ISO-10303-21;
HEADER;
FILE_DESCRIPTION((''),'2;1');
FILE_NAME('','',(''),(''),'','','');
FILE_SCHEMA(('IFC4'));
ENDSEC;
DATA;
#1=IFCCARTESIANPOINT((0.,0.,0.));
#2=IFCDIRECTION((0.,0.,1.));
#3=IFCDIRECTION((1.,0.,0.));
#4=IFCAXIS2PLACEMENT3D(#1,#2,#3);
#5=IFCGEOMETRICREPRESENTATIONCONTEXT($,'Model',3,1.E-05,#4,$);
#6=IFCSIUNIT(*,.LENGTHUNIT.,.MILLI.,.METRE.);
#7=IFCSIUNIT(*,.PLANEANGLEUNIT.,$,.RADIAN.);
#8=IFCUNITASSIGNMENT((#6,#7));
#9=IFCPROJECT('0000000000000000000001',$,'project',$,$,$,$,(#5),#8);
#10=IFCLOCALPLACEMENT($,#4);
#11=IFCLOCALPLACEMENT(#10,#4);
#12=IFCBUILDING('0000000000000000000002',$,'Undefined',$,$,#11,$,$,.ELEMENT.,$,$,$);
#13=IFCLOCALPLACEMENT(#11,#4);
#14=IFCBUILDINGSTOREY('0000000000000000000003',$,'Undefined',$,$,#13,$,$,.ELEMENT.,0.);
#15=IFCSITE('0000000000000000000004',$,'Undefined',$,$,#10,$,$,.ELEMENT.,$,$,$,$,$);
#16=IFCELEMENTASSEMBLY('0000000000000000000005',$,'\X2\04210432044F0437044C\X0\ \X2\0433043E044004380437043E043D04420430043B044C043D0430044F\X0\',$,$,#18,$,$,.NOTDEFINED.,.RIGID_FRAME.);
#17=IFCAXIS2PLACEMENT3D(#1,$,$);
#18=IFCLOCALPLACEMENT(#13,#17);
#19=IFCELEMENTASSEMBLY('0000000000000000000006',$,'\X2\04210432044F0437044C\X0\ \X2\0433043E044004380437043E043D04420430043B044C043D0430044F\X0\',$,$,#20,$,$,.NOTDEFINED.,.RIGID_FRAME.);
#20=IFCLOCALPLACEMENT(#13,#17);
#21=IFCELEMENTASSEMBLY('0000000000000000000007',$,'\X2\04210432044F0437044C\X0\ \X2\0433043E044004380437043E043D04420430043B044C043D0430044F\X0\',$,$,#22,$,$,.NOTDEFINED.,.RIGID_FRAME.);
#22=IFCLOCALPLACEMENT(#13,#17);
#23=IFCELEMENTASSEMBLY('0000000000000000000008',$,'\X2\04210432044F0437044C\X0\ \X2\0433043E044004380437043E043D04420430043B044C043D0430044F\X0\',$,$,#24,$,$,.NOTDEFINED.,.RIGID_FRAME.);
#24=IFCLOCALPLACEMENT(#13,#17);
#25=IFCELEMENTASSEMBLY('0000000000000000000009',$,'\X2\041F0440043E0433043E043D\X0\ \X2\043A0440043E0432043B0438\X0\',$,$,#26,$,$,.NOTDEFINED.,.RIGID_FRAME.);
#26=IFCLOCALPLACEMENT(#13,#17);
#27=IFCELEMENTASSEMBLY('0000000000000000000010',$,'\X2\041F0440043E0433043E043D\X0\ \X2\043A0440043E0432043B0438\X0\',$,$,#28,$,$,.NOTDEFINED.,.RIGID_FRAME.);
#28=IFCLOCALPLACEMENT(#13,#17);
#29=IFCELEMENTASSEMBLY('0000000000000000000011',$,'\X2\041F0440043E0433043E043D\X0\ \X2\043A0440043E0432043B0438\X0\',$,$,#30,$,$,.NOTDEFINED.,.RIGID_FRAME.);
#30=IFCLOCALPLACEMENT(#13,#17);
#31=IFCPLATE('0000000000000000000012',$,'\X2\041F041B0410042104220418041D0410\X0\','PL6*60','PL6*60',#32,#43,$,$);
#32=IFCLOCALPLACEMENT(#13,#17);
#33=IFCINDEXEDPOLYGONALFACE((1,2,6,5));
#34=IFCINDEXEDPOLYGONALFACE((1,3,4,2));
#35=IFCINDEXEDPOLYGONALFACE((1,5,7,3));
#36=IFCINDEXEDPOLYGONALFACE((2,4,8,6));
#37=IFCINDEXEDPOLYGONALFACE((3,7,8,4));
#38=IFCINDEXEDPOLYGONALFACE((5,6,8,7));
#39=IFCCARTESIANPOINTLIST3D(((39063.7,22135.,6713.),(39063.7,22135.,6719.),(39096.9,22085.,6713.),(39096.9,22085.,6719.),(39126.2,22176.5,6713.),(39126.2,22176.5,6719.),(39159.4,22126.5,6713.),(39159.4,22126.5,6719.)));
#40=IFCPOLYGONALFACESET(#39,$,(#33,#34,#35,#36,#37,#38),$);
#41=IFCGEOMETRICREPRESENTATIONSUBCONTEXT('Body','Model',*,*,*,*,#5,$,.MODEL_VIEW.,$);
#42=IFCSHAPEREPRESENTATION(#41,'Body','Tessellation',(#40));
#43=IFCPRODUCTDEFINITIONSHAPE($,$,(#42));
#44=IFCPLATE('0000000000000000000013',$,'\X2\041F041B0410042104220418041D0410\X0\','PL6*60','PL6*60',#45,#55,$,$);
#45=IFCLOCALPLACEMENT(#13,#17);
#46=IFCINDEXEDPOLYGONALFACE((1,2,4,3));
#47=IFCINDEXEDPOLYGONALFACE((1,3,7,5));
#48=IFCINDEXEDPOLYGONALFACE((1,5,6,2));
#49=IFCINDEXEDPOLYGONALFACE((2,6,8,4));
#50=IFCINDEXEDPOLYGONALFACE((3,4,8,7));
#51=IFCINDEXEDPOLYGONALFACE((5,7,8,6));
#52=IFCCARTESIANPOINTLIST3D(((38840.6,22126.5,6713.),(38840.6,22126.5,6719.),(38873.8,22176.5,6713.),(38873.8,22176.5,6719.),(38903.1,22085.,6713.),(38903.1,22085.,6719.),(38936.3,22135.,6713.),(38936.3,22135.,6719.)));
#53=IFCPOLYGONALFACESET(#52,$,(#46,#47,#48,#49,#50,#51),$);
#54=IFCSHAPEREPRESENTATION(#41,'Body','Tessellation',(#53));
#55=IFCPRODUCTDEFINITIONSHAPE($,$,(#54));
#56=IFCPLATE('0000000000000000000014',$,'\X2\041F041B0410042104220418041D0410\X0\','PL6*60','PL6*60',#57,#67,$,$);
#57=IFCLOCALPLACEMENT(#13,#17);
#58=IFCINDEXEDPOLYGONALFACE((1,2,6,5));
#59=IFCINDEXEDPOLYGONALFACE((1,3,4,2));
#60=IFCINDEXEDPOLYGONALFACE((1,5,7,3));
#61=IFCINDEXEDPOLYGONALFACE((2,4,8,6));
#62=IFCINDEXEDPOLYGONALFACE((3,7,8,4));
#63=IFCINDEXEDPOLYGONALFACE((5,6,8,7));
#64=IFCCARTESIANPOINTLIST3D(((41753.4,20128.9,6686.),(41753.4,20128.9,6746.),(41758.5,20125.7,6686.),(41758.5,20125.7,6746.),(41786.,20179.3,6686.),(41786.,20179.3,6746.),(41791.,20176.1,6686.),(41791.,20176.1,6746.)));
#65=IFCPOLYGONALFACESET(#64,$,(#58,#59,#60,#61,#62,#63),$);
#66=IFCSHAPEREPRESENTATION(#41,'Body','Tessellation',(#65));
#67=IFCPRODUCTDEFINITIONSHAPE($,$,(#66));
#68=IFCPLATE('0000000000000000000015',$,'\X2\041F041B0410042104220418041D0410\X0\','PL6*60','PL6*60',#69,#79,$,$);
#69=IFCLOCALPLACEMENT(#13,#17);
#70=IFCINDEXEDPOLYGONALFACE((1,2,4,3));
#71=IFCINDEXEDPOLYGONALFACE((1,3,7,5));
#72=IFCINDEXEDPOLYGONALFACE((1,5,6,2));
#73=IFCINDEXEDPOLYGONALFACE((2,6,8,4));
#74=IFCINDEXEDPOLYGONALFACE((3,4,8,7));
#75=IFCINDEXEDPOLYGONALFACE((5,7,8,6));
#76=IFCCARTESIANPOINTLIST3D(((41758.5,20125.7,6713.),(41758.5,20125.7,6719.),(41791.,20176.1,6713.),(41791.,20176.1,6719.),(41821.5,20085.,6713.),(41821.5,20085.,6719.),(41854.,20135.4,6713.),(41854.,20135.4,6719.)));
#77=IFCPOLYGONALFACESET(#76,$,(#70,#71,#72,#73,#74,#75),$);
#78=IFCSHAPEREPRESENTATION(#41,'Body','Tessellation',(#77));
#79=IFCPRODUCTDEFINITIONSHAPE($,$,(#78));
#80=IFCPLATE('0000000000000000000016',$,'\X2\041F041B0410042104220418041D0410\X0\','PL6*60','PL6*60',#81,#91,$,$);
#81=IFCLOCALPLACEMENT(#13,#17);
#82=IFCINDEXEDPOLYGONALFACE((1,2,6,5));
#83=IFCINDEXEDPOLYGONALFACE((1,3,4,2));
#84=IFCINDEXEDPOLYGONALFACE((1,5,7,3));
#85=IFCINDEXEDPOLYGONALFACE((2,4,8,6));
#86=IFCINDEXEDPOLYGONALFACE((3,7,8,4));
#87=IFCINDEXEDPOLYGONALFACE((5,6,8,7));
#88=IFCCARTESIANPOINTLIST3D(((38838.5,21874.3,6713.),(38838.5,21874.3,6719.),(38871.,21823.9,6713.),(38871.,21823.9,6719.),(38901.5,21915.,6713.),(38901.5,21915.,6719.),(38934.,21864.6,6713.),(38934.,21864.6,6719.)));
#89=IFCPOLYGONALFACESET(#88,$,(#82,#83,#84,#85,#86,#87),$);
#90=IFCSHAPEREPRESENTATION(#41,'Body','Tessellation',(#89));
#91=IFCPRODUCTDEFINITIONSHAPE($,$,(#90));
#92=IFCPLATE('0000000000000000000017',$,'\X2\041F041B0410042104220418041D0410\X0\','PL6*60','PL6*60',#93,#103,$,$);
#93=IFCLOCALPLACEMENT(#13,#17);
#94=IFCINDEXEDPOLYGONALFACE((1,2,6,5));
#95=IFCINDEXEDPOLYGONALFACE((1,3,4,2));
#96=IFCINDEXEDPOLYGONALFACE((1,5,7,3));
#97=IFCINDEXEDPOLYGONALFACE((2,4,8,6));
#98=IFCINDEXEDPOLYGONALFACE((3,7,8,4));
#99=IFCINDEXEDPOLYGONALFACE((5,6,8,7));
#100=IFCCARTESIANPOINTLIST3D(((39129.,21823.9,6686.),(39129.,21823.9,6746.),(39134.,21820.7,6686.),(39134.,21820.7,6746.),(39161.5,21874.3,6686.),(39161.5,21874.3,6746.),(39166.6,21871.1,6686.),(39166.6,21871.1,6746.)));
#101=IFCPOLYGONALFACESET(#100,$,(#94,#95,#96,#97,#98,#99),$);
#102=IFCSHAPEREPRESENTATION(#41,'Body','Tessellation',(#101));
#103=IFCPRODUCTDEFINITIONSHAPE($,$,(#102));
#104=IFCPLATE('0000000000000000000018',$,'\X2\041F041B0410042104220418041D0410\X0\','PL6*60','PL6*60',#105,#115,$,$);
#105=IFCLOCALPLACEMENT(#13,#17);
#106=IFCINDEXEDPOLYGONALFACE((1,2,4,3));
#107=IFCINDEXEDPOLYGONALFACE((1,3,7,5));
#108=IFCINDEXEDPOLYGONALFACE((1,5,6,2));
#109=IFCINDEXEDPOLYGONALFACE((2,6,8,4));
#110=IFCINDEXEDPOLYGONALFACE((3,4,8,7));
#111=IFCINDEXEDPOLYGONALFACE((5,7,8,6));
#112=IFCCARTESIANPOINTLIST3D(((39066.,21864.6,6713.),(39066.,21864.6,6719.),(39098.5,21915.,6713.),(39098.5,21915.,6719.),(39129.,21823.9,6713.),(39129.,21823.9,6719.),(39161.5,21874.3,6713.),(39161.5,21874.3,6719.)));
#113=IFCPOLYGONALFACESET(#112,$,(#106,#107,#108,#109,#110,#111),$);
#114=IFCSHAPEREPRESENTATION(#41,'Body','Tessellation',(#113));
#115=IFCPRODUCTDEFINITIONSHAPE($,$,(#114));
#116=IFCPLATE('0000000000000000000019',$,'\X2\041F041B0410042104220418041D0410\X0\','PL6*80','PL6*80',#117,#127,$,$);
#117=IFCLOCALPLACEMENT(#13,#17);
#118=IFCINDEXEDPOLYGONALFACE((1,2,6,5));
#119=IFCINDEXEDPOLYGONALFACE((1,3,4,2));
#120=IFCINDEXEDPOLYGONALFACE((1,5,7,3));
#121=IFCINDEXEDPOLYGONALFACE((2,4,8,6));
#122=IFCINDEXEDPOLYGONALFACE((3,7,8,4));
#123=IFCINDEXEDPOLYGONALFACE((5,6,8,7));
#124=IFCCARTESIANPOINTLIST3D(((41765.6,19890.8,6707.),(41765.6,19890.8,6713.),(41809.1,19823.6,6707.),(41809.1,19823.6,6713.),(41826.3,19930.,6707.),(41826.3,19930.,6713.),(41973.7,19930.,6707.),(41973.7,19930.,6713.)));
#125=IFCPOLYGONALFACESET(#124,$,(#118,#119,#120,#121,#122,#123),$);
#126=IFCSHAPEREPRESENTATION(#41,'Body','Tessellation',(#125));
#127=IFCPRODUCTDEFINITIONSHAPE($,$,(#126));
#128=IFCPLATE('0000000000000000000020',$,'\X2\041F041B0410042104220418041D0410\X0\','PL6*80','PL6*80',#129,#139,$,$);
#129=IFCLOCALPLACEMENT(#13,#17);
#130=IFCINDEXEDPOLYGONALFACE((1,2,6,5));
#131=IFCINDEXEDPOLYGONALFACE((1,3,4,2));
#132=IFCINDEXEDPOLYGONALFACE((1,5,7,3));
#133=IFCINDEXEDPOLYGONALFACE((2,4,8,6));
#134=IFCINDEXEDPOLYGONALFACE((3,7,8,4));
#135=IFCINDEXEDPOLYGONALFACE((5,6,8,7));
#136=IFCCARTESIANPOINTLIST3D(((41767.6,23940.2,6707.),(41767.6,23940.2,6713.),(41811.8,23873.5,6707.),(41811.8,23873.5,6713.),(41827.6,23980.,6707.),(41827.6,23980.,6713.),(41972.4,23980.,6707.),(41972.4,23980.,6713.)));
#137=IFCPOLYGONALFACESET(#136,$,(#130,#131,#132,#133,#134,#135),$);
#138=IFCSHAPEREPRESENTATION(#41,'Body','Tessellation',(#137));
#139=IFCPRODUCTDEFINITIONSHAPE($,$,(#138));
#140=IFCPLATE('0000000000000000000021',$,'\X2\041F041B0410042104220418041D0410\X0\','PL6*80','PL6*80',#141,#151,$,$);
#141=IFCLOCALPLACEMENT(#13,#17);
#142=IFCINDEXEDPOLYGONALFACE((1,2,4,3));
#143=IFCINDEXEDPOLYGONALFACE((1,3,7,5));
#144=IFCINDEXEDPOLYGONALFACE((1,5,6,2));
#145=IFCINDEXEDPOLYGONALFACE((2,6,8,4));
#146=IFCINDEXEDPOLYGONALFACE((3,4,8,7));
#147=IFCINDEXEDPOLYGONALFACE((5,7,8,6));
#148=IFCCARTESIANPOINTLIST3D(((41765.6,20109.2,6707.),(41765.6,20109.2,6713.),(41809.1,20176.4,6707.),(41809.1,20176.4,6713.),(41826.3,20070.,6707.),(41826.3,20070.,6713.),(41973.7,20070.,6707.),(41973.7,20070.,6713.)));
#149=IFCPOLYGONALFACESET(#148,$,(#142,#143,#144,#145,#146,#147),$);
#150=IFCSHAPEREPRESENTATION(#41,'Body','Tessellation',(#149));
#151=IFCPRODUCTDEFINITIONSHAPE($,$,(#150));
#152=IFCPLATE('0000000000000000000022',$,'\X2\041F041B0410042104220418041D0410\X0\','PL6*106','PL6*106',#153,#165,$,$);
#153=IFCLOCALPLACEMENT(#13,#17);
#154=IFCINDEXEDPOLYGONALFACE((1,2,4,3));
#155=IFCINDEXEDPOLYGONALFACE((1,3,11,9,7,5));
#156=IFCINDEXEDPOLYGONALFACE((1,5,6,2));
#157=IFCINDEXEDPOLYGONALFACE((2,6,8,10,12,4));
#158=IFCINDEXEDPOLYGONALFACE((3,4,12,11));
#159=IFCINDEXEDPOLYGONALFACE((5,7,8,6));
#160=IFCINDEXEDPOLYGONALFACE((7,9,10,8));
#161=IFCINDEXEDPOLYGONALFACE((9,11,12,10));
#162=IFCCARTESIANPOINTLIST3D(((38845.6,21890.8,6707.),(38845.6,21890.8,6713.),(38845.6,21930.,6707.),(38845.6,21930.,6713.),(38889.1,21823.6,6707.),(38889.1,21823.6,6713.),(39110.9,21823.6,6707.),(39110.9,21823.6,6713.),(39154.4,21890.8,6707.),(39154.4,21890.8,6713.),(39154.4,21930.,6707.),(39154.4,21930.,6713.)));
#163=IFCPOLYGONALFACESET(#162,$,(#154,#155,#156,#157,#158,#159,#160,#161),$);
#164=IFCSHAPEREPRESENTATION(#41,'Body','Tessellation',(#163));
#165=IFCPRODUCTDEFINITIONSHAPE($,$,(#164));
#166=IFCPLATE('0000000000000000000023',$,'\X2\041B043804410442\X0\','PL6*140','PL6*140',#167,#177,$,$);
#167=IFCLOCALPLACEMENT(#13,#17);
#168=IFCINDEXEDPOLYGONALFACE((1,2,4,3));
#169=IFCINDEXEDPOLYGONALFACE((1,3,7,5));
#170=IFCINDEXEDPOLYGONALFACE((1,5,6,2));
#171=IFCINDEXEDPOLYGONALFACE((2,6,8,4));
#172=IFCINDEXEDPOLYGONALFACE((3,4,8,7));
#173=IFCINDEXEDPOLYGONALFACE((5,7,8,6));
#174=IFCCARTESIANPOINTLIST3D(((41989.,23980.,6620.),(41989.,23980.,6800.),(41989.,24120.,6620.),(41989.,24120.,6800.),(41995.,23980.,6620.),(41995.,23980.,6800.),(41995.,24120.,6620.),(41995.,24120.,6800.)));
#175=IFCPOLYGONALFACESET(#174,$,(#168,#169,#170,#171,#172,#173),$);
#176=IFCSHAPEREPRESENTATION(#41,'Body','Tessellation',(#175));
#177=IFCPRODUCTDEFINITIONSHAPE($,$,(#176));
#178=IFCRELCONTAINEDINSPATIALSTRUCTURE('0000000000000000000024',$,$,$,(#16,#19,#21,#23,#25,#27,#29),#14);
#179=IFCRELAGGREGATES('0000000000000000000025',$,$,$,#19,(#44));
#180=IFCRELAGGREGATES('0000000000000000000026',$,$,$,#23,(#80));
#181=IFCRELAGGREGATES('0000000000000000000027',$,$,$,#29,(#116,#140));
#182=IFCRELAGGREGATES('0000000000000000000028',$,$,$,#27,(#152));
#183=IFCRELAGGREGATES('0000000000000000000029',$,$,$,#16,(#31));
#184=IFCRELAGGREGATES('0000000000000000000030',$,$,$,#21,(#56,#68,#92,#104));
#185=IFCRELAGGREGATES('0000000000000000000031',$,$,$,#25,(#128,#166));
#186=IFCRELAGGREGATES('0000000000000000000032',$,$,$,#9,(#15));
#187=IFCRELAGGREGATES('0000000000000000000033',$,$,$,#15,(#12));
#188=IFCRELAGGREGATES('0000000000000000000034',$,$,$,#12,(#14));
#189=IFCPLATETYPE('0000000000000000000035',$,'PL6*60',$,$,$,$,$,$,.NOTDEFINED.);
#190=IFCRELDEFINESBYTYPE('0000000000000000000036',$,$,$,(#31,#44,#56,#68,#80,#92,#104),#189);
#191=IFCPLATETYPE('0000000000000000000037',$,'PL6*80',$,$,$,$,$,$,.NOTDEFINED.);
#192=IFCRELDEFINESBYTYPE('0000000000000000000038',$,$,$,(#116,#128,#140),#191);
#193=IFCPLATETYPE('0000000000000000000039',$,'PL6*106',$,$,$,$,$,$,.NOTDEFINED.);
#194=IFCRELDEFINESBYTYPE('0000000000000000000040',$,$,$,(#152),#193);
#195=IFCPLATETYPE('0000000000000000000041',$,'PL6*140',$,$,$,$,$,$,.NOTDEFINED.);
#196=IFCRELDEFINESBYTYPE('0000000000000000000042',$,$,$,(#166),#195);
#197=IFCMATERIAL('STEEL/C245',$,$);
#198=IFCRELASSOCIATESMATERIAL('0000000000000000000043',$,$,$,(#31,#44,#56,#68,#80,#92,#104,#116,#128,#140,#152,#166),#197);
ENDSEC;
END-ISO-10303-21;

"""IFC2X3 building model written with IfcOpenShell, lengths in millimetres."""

from ifc_helpers import new_model, si_unit, frame, origin_with_axes, place, context, subcontext, project, spatial, polyline, outline, extrude, material, type_object, element, aggregate, save


model = new_model("IFC2X3")

# Units and contexts
model_context = context("Model", 3, precision=1e-05, world=origin_with_axes())
body_context = subcontext(model_context, "Body", "Model", "MODEL_VIEW")
ifc_project = project(units=[si_unit("LENGTHUNIT", "METRE", prefix="MILLI"), si_unit("PLANEANGLEUNIT", "RADIAN")], contexts=[model_context])

# Site, building, storey
site_placement = place(None, origin_with_axes())
site = spatial("IfcSite", under=ifc_project, at=site_placement, Name="Undefined", CompositionType="ELEMENT")
building_placement = place(site_placement, origin_with_axes())
building = spatial("IfcBuilding", under=site, at=building_placement, Name="Undefined", CompositionType="ELEMENT")
storey_placement = place(building_placement, origin_with_axes())
storey = spatial("IfcBuildingStorey", under=building, at=storey_placement, Name="Undefined", CompositionType="ELEMENT", Elevation=0.0)

# Element assemblies
assembly_1_placement = place(storey_placement, origin_with_axes())
assembly_1 = element("IfcElementAssembly", 1, at=assembly_1_placement, inside=storey, Name="Связь горизонтальная", AssemblyPlace="NOTDEFINED", PredefinedType="RIGID_FRAME")
ifc_material_1 = material(Name="STEEL/C245")
assembly_2_placement = place(storey_placement, origin_with_axes())
assembly_2 = element("IfcElementAssembly", 2, at=assembly_2_placement, inside=storey, Name="Связь горизонтальная", AssemblyPlace="NOTDEFINED", PredefinedType="RIGID_FRAME")
assembly_3_placement = place(storey_placement, origin_with_axes())
assembly_3 = element("IfcElementAssembly", 3, at=assembly_3_placement, inside=storey, Name="Связь горизонтальная", AssemblyPlace="NOTDEFINED", PredefinedType="RIGID_FRAME")
assembly_4_placement = place(storey_placement, origin_with_axes())
assembly_4 = element("IfcElementAssembly", 4, at=assembly_4_placement, inside=storey, Name="Связь горизонтальная", AssemblyPlace="NOTDEFINED", PredefinedType="RIGID_FRAME")
assembly_5_placement = place(storey_placement, origin_with_axes())
assembly_5 = element("IfcElementAssembly", 5, at=assembly_5_placement, inside=storey, Name="Прогон кровли", AssemblyPlace="NOTDEFINED", PredefinedType="RIGID_FRAME")

# Element assemblies
assembly_6_placement = place(storey_placement, origin_with_axes())
assembly_6 = element("IfcElementAssembly", 6, at=assembly_6_placement, inside=storey, Name="Прогон кровли", AssemblyPlace="NOTDEFINED", PredefinedType="RIGID_FRAME")
assembly_7_placement = place(storey_placement, origin_with_axes())
assembly_7 = element("IfcElementAssembly", 7, at=assembly_7_placement, inside=storey, Name="Прогон кровли", AssemblyPlace="NOTDEFINED", PredefinedType="RIGID_FRAME")

# Shared definitions
plate_type_1 = type_object("IfcPlateType", Name="PL6*60", PredefinedType="NOTDEFINED")

# Plates
plate_1_placement = place(assembly_1_placement, frame((39080.3, 22110.0, 6716.0), z_axis=(0.0, 0.0, -1.0), x_axis=(0.833383, 0.552695, 0.0)))
plate_1 = element("IfcPlate", 8, at=plate_1_placement, type_object=plate_type_1, material=ifc_material_1, Name="ПЛАСТИНА", Description="PL6*60", ObjectType="PL6*60", context=body_context, shape_type="SweptSolid", body=[
    extrude(outline(polyline([(0.0, -30.0), (0.0, 30.0), (75.0, 30.0), (75.0, -30.0), (0.0, -30.0)])), frame((0.0, 0.0, -3.0), z_axis=(0.0, 0.0, 1.0), x_axis=(1.0, 0.0, 0.0)), (0.0, 0.0, 1.0), 6.0),
])
plate_2_placement = place(assembly_2_placement, frame((38919.7, 22110.0, 6716.0), z_axis=(0.0, 0.0, -1.0), x_axis=(-0.833383, 0.552695, 0.0)))
plate_2 = element("IfcPlate", 9, at=plate_2_placement, type_object=plate_type_1, material=ifc_material_1, Name="ПЛАСТИНА", Description="PL6*60", ObjectType="PL6*60", context=body_context, shape_type="SweptSolid", body=[
    extrude(outline(polyline([(75.0, -30.0), (0.0, -30.0), (0.0, 30.0), (75.0, 30.0), (75.0, -30.0)])), frame((0.0, 0.0, -3.0), z_axis=(0.0, 0.0, 1.0), x_axis=(1.0, 0.0, 0.0)), (0.0, 0.0, 1.0), 6.0),
])
aggregate(assembly_2, [plate_2])
plate_3_placement = place(assembly_3_placement, frame((41772.2, 20152.5, 6746.0), z_axis=(0.840039, -0.542525, 0.0), x_axis=(0.0, 0.0, -1.0)))
plate_3 = element("IfcPlate", 10, at=plate_3_placement, type_object=plate_type_1, material=ifc_material_1, Name="ПЛАСТИНА", Description="PL6*60", ObjectType="PL6*60", context=body_context, shape_type="SweptSolid", body=[
    extrude(outline(polyline([(60.0, -30.0), (0.0, -30.0), (0.0, 30.0), (60.0, 30.0), (60.0, -30.0)])), frame((0.0, 0.0, -3.0), z_axis=(0.0, 0.0, 1.0), x_axis=(1.0, 0.0, 0.0)), (0.0, 0.0, 1.0), 6.0),
])
plate_4_placement = place(assembly_3_placement, frame((41837.8, 20110.2, 6716.0), z_axis=(0.0, 0.0, 1.0), x_axis=(-0.840039, 0.542525, 0.0)))
plate_4 = element("IfcPlate", 11, at=plate_4_placement, type_object=plate_type_1, material=ifc_material_1, Name="ПЛАСТИНА", Description="PL6*60", ObjectType="PL6*60", context=body_context, shape_type="SweptSolid", body=[
    extrude(outline(polyline([(75.0, 30.0), (75.0, -30.0), (0.0, -30.0), (0.0, 30.0), (75.0, 30.0)])), frame((0.0, 0.0, -3.0), z_axis=(0.0, 0.0, 1.0), x_axis=(1.0, 0.0, 0.0)), (0.0, 0.0, 1.0), 6.0),
])
plate_5_placement = place(assembly_4_placement, frame((38917.8, 21889.8, 6716.0), z_axis=(0.0, 0.0, -1.0), x_axis=(-0.840039, -0.542525, 0.0)))
plate_5 = element("IfcPlate", 12, at=plate_5_placement, type_object=plate_type_1, material=ifc_material_1, Name="ПЛАСТИНА", Description="PL6*60", ObjectType="PL6*60", context=body_context, shape_type="SweptSolid", body=[
    extrude(outline(polyline([(75.0, 30.0), (75.0, -30.0), (0.0, -30.0), (0.0, 30.0), (75.0, 30.0)])), frame((0.0, 0.0, -3.0), z_axis=(0.0, 0.0, 1.0), x_axis=(1.0, 0.0, 0.0)), (0.0, 0.0, 1.0), 6.0),
])
aggregate(assembly_4, [plate_5])
plate_6_placement = place(assembly_3_placement, frame((39147.8, 21847.5, 6686.0), z_axis=(-0.840039, 0.542525, 0.0), x_axis=(0.0, 0.0, 1.0)))
plate_6 = element("IfcPlate", 13, at=plate_6_placement, type_object=plate_type_1, material=ifc_material_1, Name="ПЛАСТИНА", Description="PL6*60", ObjectType="PL6*60", context=body_context, shape_type="SweptSolid", body=[
    extrude(outline(polyline([(0.0, -30.0), (0.0, 30.0), (60.0, 30.0), (60.0, -30.0), (0.0, -30.0)])), frame((0.0, 0.0, -3.0), z_axis=(0.0, 0.0, 1.0), x_axis=(1.0, 0.0, 0.0)), (0.0, 0.0, 1.0), 6.0),
])
plate_7_placement = place(assembly_3_placement, frame((39082.2, 21889.8, 6716.0), z_axis=(0.0, 0.0, -1.0), x_axis=(0.840039, -0.542525, 0.0)))
plate_7 = element("IfcPlate", 14, at=plate_7_placement, type_object=plate_type_1, material=ifc_material_1, Name="ПЛАСТИНА", Description="PL6*60", ObjectType="PL6*60", context=body_context, shape_type="SweptSolid", body=[
    extrude(outline(polyline([(0.0, 30.0), (75.0, 30.0), (75.0, -30.0), (0.0, -30.0), (0.0, 30.0)])), frame((0.0, 0.0, -3.0), z_axis=(0.0, 0.0, 1.0), x_axis=(1.0, 0.0, 0.0)), (0.0, 0.0, 1.0), 6.0),
])
plate_type_2 = type_object("IfcPlateType", Name="PL6*80", PredefinedType="NOTDEFINED")
plate_8_placement = place(assembly_7_placement, frame((41973.7, 19930.0, 6710.0), z_axis=(0.0, 0.0, -1.0), x_axis=(-0.840039, -0.542525, 0.0)))
plate_8 = element("IfcPlate", 15, at=plate_8_placement, type_object=plate_type_2, material=ifc_material_1, Name="ПЛАСТИНА", Description="PL6*80", ObjectType="PL6*80", context=body_context, shape_type="SweptSolid", body=[
    extrude(outline(polyline([(0.0, 0.0), (196.0, 0.0), (196.0, 80.0), (123.9, 80.0), (0.0, 0.0)])), frame((0.0, 0.0, -3.0), z_axis=(0.0, 0.0, 1.0), x_axis=(1.0, 0.0, 0.0)), (0.0, 0.0, 1.0), 6.0),
])
plate_9_placement = place(assembly_5_placement, frame((41972.4, 23980.0, 6710.0), z_axis=(0.0, 0.0, -1.0), x_axis=(-0.833383, -0.552695, 0.0)))
plate_9 = element("IfcPlate", 16, at=plate_9_placement, type_object=plate_type_2, material=ifc_material_1, Name="ПЛАСТИНА", Description="PL6*80", ObjectType="PL6*80", context=body_context, shape_type="SweptSolid", body=[
    extrude(outline(polyline([(0.0, 0.0), (192.7, 0.0), (192.7, 80.0), (120.6, 80.0), (0.0, 0.0)])), frame((0.0, 0.0, -3.0), z_axis=(0.0, 0.0, 1.0), x_axis=(1.0, 0.0, 0.0)), (0.0, 0.0, 1.0), 6.0),
])
plate_10_placement = place(assembly_7_placement, frame((41973.7, 20070.0, 6710.0), z_axis=(0.0, 0.0, 1.0), x_axis=(-0.840039, 0.542525, 0.0)))
plate_10 = element("IfcPlate", 17, at=plate_10_placement, type_object=plate_type_2, material=ifc_material_1, Name="ПЛАСТИНА", Description="PL6*80", ObjectType="PL6*80", context=body_context, shape_type="SweptSolid", body=[
    extrude(outline(polyline([(0.0, 0.0), (196.0, 0.0), (196.0, 80.0), (123.9, 80.0), (0.0, 0.0)])), frame((0.0, 0.0, -3.0), z_axis=(0.0, 0.0, 1.0), x_axis=(1.0, 0.0, 0.0)), (0.0, 0.0, 1.0), 6.0),
])
aggregate(assembly_7, [plate_8, plate_10])
plate_type_3 = type_object("IfcPlateType", Name="PL6*106", PredefinedType="NOTDEFINED")
plate_11_placement = place(assembly_6_placement, frame((39154.4, 21930.0, 6710.0), z_axis=(0.0, 0.0, -1.0), x_axis=(0.0, -1.0, 0.0)))
plate_11 = element("IfcPlate", 18, at=plate_11_placement, type_object=plate_type_3, material=ifc_material_1, Name="ПЛАСТИНА", Description="PL6*106", ObjectType="PL6*106", context=body_context, shape_type="SweptSolid", body=[
    extrude(outline(polyline([(0.0, 0.0), (39.2, 0.0), (106.4, 43.4), (106.4, 265.3), (39.2, 308.7), (0.0, 308.7), (0.0, 0.0)])), frame((0.0, 0.0, -3.0), z_axis=(0.0, 0.0, 1.0), x_axis=(1.0, 0.0, 0.0)), (0.0, 0.0, 1.0), 6.0),
])
aggregate(assembly_6, [plate_11])
plate_type_4 = type_object("IfcPlateType", Name="PL6*140", PredefinedType="NOTDEFINED")
plate_12_placement = place(assembly_5_placement, frame((41992.0, 24050.0, 6620.0), z_axis=(-1.0, 0.0, 0.0), x_axis=(0.0, 0.0, 1.0)))
plate_12 = element("IfcPlate", 19, at=plate_12_placement, type_object=plate_type_4, material=ifc_material_1, Name="Лист", Description="PL6*140", ObjectType="PL6*140", context=body_context, shape_type="SweptSolid", body=[
    extrude(outline(polyline([(0.0, -70.0), (0.0, 70.0), (180.0, 70.0), (180.0, -70.0), (0.0, -70.0)])), frame((0.0, 0.0, -3.0), z_axis=(0.0, 0.0, 1.0), x_axis=(1.0, 0.0, 0.0)), (0.0, 0.0, 1.0), 6.0),
])

aggregate(assembly_1, [plate_1])
aggregate(assembly_3, [plate_3, plate_4, plate_6, plate_7])
aggregate(assembly_5, [plate_9, plate_12])

save(model, "model.ifc")
